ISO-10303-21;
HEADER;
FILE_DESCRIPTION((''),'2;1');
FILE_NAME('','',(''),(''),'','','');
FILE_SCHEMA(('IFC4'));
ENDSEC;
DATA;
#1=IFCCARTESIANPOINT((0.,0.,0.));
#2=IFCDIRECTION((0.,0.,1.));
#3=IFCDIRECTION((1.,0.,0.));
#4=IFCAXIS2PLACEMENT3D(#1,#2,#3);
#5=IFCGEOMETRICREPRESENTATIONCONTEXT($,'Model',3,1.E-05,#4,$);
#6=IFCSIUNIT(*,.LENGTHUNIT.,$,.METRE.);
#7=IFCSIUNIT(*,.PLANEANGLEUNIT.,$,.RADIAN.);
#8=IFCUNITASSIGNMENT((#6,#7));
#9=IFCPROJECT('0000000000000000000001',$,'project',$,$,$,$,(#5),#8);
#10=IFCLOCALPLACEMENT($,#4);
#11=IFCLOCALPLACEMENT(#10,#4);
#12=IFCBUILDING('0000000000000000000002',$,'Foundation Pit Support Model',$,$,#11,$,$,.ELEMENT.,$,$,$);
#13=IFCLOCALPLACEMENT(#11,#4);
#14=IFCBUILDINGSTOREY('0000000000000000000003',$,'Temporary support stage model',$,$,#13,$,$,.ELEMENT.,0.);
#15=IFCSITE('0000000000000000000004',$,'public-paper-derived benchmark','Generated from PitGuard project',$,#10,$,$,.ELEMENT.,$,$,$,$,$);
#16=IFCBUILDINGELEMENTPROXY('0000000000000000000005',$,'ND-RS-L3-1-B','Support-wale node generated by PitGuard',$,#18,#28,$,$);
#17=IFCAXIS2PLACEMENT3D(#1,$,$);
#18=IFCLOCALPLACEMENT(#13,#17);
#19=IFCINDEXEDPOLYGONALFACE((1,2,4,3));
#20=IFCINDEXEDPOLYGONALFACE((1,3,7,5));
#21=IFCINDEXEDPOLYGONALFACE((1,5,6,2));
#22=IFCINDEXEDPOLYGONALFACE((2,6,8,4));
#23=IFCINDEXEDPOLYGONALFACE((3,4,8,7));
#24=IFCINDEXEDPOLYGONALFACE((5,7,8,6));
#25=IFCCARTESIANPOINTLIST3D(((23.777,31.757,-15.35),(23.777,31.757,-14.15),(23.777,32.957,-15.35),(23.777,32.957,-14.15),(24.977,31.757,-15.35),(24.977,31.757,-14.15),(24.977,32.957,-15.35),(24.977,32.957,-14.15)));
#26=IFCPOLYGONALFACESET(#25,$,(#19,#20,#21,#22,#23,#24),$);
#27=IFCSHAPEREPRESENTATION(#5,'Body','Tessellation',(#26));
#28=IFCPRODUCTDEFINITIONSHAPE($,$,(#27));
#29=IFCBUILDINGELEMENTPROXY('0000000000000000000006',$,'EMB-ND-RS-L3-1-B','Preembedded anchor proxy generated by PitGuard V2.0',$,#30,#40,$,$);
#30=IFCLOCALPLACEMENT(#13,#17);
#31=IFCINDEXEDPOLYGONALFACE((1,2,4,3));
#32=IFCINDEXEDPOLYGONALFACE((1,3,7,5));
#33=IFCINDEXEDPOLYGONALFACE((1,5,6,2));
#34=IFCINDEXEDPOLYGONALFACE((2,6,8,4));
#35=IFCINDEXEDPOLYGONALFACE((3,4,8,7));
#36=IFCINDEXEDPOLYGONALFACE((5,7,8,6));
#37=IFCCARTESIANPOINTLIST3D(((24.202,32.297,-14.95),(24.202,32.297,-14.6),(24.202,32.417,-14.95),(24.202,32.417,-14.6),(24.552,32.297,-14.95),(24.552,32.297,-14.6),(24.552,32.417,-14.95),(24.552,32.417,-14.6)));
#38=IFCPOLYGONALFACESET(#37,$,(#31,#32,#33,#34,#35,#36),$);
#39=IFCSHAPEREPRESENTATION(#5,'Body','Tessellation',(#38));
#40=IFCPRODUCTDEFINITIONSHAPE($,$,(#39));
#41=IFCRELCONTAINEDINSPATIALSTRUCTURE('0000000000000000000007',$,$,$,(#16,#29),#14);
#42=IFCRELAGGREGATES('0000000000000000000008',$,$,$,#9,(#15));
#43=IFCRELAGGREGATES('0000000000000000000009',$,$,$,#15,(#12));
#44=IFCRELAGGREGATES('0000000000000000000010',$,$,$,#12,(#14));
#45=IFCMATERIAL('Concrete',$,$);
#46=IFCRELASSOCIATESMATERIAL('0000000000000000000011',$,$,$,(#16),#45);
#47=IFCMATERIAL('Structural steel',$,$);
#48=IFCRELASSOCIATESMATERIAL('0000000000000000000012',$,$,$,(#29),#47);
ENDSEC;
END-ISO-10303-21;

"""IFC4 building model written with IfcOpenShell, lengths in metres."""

from ifc_helpers import new_model, si_unit, frame, origin_with_axes, origin_2d, place, context, project, spatial, rectangle, extrude, material, element, save


model = new_model("IFC4")

# Units and contexts
model_context = context("Model", 3, precision=1e-05, world=origin_with_axes())
ifc_project = project(units=[si_unit("LENGTHUNIT", "METRE"), si_unit("PLANEANGLEUNIT", "RADIAN")], contexts=[model_context])

# Site, building, storey
site_placement = place(None, origin_with_axes())
site = spatial("IfcSite", under=ifc_project, at=site_placement, Name="public-paper-derived benchmark", Description="Generated from PitGuard project", CompositionType="ELEMENT")
building_placement = place(site_placement, origin_with_axes())
building = spatial("IfcBuilding", under=site, at=building_placement, Name="Foundation Pit Support Model", CompositionType="ELEMENT")
storey_placement = place(building_placement, origin_with_axes())
storey = spatial("IfcBuildingStorey", under=building, at=storey_placement, Name="Temporary support stage model", CompositionType="ELEMENT", Elevation=0.0)

# Shared definitions
ifc_material_1 = material(Name="Concrete")

# Shared definitions
ifc_material_2 = material(Name="Structural steel")

# Building element proxies
proxy_1_placement = place(storey_placement, frame((24.377, 32.357, -15.35), z_axis=(0.0, 0.0, 1.0), x_axis=(1.0, 0.0, 0.0)))
element("IfcBuildingElementProxy", 1, at=proxy_1_placement, inside=storey, material=ifc_material_1, Name="ND-RS-L3-1-B", Description="Support-wale node generated by PitGuard", context=model_context, shape_type="SweptSolid", body=[
    extrude(rectangle(XDim=1.2, YDim=1.2, at=origin_2d()), origin_with_axes(), (0.0, 0.0, 1.0), 1.2),
])
proxy_2_placement = place(storey_placement, frame((24.377, 32.357, -14.95), z_axis=(0.0, 0.0, 1.0), x_axis=(1.0, 0.0, 0.0)))
element("IfcBuildingElementProxy", 2, at=proxy_2_placement, inside=storey, material=ifc_material_2, Name="EMB-ND-RS-L3-1-B", Description="Preembedded anchor proxy generated by PitGuard V2.0", context=model_context, shape_type="SweptSolid", body=[
    extrude(rectangle(XDim=0.35, YDim=0.12, at=origin_2d()), origin_with_axes(), (0.0, 0.0, 1.0), 0.35),
])

save(model, "model.ifc")
